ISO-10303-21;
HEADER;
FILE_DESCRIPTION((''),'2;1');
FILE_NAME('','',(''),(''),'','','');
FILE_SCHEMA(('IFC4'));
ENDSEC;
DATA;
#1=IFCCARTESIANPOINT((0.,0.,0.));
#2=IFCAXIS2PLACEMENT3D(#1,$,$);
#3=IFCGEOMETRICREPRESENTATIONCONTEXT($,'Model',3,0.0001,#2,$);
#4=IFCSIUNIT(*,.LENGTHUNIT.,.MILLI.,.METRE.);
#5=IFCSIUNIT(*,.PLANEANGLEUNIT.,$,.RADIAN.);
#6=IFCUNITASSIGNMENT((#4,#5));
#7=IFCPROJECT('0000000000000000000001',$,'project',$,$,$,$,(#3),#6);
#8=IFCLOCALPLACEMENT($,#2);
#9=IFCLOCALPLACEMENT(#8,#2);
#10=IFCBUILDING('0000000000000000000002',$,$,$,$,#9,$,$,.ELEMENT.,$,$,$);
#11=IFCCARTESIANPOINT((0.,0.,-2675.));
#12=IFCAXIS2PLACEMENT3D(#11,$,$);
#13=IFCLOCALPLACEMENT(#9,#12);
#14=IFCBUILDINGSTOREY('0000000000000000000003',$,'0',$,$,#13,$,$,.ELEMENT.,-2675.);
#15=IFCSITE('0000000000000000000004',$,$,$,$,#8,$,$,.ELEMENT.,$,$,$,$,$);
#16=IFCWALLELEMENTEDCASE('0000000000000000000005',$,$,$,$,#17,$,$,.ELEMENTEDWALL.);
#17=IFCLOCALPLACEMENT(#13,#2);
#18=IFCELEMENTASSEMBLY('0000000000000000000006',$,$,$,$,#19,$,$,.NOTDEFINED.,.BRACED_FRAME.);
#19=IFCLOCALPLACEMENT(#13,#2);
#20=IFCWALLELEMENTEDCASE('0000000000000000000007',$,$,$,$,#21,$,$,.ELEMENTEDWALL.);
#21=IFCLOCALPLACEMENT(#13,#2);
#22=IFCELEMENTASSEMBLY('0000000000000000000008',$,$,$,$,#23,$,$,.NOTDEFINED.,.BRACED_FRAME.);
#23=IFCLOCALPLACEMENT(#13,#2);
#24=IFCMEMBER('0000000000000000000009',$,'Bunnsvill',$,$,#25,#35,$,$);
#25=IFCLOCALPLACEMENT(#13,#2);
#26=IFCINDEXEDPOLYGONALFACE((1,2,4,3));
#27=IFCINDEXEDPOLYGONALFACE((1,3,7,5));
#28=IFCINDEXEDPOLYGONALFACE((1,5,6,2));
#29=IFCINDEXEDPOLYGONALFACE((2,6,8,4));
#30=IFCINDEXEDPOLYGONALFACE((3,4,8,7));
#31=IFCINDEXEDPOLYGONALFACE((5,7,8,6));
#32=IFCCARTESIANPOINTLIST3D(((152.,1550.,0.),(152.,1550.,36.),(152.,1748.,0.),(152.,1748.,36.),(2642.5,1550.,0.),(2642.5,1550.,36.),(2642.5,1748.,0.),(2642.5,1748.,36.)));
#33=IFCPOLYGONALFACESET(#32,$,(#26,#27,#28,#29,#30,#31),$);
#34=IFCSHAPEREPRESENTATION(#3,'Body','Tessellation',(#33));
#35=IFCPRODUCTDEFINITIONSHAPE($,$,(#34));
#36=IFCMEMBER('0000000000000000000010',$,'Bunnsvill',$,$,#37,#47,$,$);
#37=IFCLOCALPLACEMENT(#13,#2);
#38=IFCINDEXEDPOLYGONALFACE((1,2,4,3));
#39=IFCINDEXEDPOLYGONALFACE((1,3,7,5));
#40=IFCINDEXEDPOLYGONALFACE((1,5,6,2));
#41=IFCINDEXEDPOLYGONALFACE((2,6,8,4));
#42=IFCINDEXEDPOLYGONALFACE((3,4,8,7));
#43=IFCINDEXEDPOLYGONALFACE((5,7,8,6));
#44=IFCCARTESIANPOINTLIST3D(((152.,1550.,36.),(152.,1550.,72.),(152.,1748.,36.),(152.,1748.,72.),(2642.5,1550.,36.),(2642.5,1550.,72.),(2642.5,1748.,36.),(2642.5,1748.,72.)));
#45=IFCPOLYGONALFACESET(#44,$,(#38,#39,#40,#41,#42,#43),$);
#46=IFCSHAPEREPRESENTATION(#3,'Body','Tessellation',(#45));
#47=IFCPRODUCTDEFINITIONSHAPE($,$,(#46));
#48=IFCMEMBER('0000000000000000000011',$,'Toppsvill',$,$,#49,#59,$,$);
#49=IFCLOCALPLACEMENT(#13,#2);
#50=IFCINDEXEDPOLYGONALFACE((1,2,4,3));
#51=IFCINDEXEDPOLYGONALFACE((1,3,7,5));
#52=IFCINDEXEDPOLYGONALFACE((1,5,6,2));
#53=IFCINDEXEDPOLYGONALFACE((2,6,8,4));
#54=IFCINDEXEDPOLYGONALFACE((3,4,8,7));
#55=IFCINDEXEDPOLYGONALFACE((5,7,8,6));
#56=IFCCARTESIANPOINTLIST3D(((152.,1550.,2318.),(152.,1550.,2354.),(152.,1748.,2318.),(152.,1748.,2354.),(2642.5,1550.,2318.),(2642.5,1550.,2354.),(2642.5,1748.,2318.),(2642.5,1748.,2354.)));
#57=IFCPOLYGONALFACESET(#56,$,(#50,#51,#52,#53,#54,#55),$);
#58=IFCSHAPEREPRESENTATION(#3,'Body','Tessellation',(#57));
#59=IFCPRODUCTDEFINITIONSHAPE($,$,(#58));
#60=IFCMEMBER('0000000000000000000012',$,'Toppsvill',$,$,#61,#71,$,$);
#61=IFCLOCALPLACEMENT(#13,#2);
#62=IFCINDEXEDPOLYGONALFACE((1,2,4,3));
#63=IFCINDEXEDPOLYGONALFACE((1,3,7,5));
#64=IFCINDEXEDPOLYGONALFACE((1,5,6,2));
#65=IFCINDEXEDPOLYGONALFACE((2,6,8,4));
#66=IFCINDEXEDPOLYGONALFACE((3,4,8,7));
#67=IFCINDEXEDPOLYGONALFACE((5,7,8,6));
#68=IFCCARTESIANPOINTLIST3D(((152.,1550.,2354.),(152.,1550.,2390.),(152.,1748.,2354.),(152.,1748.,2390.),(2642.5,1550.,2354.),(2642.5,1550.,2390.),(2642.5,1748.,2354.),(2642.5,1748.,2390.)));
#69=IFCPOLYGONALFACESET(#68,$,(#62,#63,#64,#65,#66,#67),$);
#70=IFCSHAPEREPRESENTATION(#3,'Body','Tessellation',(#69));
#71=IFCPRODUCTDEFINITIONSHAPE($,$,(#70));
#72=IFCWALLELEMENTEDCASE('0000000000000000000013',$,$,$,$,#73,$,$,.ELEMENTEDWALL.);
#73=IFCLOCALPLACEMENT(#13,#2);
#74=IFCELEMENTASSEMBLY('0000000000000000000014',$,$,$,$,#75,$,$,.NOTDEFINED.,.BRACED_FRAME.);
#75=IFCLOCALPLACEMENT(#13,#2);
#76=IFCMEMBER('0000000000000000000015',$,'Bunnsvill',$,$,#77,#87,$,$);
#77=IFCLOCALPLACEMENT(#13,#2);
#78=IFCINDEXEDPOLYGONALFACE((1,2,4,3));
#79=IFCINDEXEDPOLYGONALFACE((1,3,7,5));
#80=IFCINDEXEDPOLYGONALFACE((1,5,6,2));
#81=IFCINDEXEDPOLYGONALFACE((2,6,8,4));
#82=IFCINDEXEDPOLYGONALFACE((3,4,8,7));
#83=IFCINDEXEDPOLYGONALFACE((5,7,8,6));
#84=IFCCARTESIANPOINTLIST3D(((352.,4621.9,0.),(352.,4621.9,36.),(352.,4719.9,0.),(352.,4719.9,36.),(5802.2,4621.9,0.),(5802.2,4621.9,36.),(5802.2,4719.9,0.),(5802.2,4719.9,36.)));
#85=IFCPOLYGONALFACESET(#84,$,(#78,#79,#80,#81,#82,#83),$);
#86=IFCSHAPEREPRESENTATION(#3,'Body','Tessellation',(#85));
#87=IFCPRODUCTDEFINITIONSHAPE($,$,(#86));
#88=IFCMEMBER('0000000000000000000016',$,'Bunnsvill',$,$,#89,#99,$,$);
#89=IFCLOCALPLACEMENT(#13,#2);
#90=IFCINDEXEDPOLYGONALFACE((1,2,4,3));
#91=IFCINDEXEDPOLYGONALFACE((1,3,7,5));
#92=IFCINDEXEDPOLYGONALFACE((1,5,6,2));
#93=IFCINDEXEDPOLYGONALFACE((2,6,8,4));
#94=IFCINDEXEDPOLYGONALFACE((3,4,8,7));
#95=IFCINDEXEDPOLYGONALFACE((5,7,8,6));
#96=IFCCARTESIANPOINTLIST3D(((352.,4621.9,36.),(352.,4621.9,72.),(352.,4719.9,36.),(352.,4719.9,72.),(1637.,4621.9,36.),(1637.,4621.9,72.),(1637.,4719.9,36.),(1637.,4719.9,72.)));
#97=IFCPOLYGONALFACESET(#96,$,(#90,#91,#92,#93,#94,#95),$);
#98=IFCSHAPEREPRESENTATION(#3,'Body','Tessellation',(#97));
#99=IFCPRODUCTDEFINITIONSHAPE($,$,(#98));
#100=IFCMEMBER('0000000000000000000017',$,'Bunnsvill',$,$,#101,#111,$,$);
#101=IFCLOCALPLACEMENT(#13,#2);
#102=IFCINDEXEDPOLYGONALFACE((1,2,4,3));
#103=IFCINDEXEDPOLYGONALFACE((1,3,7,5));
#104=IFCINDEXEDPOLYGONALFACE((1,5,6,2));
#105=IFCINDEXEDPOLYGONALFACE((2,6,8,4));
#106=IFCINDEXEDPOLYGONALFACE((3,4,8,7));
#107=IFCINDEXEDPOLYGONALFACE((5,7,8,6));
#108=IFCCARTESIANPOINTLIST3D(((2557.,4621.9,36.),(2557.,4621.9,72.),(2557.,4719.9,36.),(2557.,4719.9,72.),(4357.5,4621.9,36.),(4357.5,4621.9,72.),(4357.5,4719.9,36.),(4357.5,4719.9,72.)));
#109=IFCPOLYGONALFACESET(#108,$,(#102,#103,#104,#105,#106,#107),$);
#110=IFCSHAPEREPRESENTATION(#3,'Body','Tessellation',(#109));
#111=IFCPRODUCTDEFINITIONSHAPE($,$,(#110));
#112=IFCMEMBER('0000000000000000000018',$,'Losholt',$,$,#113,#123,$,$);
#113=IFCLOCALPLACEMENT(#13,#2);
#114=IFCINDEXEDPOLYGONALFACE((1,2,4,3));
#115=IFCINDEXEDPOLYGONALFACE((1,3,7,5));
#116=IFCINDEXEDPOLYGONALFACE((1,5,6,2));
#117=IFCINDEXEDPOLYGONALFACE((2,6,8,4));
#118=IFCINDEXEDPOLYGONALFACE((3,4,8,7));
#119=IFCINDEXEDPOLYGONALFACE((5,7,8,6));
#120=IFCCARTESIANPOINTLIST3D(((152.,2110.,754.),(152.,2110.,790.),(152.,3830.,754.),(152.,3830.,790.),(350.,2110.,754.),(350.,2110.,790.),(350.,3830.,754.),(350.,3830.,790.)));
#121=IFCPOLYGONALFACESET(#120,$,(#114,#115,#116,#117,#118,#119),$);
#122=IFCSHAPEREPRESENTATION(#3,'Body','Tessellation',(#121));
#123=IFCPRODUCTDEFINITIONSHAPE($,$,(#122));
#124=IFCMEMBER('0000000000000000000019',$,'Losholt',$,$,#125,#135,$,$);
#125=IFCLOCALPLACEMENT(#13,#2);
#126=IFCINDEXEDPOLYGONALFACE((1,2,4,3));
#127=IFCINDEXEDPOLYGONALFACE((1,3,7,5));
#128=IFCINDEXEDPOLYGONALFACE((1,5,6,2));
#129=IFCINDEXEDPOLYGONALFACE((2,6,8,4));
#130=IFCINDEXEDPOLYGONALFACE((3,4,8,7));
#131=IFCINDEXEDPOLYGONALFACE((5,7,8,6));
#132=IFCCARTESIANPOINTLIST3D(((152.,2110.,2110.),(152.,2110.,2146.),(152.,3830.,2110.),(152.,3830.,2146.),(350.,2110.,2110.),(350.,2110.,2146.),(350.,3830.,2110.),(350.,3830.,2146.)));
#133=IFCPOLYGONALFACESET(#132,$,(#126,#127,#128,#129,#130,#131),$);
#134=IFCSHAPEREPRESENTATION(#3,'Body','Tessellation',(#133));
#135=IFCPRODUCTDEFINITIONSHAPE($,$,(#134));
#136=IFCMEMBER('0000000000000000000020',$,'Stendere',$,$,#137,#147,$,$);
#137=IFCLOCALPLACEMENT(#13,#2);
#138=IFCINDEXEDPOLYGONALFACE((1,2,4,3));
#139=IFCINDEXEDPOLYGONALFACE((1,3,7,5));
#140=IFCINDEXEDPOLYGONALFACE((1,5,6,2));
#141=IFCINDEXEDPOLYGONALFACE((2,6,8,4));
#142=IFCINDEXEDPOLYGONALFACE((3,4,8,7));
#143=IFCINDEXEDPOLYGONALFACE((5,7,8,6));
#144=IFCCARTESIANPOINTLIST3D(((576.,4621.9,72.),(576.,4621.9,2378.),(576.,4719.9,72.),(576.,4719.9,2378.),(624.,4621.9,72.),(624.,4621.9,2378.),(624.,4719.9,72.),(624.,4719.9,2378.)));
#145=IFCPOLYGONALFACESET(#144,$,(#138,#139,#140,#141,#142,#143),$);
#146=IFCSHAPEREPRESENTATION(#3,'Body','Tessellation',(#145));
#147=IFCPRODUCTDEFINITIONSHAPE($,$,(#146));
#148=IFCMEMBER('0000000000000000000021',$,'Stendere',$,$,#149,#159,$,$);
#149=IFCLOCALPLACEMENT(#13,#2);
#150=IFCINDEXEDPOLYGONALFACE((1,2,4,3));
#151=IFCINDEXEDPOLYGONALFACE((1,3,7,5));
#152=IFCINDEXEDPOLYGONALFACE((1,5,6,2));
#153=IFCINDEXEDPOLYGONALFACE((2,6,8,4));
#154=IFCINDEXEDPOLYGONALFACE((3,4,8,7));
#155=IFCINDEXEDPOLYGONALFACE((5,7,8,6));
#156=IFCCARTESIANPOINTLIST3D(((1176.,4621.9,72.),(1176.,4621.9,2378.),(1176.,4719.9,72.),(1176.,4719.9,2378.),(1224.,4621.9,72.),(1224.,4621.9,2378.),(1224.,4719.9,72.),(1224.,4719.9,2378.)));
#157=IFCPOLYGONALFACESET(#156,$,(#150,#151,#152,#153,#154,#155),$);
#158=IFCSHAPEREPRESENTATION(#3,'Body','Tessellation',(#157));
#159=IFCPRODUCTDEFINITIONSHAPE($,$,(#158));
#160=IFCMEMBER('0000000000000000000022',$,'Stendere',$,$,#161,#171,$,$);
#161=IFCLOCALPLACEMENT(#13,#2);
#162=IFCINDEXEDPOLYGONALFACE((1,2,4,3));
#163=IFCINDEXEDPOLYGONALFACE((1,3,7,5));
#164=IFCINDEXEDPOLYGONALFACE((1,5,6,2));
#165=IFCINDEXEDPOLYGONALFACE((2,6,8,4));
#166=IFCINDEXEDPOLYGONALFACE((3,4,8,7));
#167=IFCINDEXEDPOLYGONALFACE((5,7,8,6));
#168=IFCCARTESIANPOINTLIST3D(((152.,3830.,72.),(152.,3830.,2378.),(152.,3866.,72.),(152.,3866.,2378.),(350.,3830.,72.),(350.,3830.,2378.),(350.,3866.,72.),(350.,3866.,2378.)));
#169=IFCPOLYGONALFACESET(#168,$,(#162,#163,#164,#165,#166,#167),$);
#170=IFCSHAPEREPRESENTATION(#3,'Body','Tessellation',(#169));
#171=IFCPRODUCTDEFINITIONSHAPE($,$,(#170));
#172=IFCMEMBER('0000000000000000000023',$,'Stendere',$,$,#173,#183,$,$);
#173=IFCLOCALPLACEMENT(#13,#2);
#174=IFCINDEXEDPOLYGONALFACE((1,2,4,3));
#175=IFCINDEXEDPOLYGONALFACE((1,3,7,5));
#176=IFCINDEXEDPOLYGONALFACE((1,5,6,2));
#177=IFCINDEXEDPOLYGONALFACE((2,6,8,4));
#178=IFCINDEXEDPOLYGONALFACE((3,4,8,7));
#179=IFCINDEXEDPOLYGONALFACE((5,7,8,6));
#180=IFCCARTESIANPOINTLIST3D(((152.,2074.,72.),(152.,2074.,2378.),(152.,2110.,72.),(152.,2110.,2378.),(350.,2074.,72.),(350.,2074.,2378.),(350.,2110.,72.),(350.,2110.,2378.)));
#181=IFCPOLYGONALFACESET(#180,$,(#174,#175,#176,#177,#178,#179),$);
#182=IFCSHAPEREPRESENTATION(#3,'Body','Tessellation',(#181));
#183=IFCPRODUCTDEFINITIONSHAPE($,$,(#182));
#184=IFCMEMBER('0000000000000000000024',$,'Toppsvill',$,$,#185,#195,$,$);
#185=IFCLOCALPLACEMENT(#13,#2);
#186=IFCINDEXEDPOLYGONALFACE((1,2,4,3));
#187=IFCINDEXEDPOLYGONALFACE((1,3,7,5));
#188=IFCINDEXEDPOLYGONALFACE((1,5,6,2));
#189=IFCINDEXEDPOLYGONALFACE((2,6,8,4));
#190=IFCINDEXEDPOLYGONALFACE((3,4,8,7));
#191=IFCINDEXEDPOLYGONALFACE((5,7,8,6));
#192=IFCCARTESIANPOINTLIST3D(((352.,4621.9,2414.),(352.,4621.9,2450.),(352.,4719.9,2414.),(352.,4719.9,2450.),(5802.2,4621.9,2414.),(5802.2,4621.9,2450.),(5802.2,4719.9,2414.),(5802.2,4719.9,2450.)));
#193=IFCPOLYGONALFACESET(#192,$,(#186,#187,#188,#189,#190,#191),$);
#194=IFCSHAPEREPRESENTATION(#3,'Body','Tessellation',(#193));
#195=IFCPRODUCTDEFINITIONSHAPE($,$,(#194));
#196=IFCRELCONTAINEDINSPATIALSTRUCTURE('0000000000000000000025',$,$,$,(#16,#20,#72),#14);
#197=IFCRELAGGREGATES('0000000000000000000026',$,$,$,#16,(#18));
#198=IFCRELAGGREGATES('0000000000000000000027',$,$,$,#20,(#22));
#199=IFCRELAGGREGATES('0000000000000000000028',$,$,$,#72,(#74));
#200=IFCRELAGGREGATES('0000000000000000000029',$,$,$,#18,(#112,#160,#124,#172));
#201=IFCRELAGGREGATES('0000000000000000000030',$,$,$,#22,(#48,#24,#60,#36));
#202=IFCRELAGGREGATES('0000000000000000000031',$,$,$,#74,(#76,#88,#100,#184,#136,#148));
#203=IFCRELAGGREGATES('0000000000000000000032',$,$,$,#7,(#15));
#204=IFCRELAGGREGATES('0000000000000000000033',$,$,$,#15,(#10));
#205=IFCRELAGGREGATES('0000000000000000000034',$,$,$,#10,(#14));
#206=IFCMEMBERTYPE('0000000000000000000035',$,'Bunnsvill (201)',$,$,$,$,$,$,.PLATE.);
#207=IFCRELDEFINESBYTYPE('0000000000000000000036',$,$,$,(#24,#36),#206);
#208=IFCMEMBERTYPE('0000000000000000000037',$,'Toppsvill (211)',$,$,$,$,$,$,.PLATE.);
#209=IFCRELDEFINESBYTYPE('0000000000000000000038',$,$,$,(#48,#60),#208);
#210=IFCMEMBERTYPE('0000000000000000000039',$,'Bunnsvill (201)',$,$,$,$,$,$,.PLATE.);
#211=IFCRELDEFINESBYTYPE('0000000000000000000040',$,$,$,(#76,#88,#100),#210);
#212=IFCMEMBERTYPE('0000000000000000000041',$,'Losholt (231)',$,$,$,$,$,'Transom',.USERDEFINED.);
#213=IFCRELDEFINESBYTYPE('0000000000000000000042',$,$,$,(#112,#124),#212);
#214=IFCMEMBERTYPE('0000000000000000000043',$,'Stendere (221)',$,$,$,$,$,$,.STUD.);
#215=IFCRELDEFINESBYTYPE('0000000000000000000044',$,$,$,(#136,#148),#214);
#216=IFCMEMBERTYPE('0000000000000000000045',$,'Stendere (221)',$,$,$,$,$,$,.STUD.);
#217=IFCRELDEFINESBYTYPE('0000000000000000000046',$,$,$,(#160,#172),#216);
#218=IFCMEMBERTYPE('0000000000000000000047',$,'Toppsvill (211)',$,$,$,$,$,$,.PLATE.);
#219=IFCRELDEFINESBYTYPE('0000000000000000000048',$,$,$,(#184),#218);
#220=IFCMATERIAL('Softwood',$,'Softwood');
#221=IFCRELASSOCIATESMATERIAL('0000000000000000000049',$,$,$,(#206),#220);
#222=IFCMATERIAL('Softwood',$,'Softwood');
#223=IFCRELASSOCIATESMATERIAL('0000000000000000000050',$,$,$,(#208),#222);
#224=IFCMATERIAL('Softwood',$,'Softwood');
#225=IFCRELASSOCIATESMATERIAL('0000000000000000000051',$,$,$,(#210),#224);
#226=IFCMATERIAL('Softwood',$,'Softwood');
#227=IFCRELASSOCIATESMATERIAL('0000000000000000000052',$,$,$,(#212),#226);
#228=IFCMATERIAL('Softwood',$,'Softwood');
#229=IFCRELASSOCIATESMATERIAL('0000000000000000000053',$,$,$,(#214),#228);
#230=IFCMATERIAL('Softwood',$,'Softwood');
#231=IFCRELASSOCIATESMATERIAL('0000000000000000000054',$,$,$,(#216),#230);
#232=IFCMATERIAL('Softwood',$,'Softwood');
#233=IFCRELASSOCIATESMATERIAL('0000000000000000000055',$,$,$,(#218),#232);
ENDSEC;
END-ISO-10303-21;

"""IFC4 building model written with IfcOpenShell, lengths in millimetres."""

from ifc_helpers import new_model, si_unit, frame, origin, place, context, project, spatial, rectangle, extrude, material, material_profile, profile_set, type_object, element, aggregate, save


model = new_model("IFC4")

# Units and contexts
model_context = context("Model", 3, precision=0.0001, world=origin())
ifc_project = project(units=[si_unit("LENGTHUNIT", "METRE", prefix="MILLI"), si_unit("PLANEANGLEUNIT", "RADIAN")], contexts=[model_context])

# Site, building, storey
site_placement = place(None, origin())
site = spatial("IfcSite", under=ifc_project, at=site_placement, CompositionType="ELEMENT")
building_placement = place(site_placement, origin())
building = spatial("IfcBuilding", under=site, at=building_placement, CompositionType="ELEMENT")
storey_placement = place(building_placement, frame((0.0, 0.0, -2675.0)))
storey = spatial("IfcBuildingStorey", under=building, at=storey_placement, Name="0", CompositionType="ELEMENT", Elevation=-2675.0)

# Walls, element assemblies
wall_1_placement = place(storey_placement, frame((350.0, 6150.0, 0.0), z_axis=(-1.0, 0.0, 0.0), x_axis=(0.0, -1.0, 0.0)))
wall_1 = element("IfcWallElementedCase", 1, at=wall_1_placement, inside=storey, PredefinedType="ELEMENTEDWALL")
assembly_1_placement = place(wall_1_placement, origin())
assembly_1 = element("IfcElementAssembly", 2, at=assembly_1_placement, AssemblyPlace="NOTDEFINED", PredefinedType="BRACED_FRAME")
aggregate(wall_1, [assembly_1])
wall_2_placement = place(storey_placement, frame((350.0, 1748.0, 0.0), z_axis=(0.0, -1.0, 0.0)))
wall_2 = element("IfcWallElementedCase", 3, at=wall_2_placement, inside=storey, PredefinedType="ELEMENTEDWALL")
assembly_2_placement = place(wall_2_placement, origin())
assembly_2 = element("IfcElementAssembly", 4, at=assembly_2_placement, AssemblyPlace="NOTDEFINED", PredefinedType="BRACED_FRAME")
aggregate(wall_2, [assembly_2])

# Members
ifc_material_1 = material(Name="Softwood", Category="Softwood")
ifc_material_profile_1 = material_profile(ifc_material_1, rectangle(XDim=36.0, YDim=198.0), Name="Bunnsvill (201)")
ifc_profile_set_1 = profile_set([ifc_material_profile_1])
member_type_1 = type_object("IfcMemberType", Name="Bunnsvill (201)", PredefinedType="PLATE", material=ifc_profile_set_1)
member_1_placement = place(assembly_2_placement, frame((-198.0, 18.0, 0.0), z_axis=(1.0, 0.0, 0.0), x_axis=(0.0, 1.0, 0.0)))
member_1 = element("IfcMember", 5, at=member_1_placement, type_object=member_type_1, Name="Bunnsvill", context=model_context, shape_type="SweptSolid", body=[
    extrude(rectangle(XDim=36.0, YDim=198.0), frame((0.0, 99.0, 0.0)), (0.0, 0.0, 1.0), 2490.5),
])
member_2_placement = place(assembly_2_placement, frame((-198.0, 54.0, 0.0), z_axis=(1.0, 0.0, 0.0), x_axis=(0.0, 1.0, 0.0)))
member_2 = element("IfcMember", 6, at=member_2_placement, type_object=member_type_1, Name="Bunnsvill", context=model_context, shape_type="SweptSolid", body=[
    extrude(rectangle(XDim=36.0, YDim=198.0), frame((0.0, 99.0, 0.0)), (0.0, 0.0, 1.0), 2490.5),
])
ifc_material_2 = material(Name="Softwood", Category="Softwood")
ifc_material_profile_2 = material_profile(ifc_material_2, rectangle(XDim=36.0, YDim=198.0), Name="Toppsvill (211)")
ifc_profile_set_2 = profile_set([ifc_material_profile_2])
member_type_2 = type_object("IfcMemberType", Name="Toppsvill (211)", PredefinedType="PLATE", material=ifc_profile_set_2)
member_3_placement = place(assembly_2_placement, frame((-198.0, 2336.0, 0.0), z_axis=(1.0, 0.0, 0.0), x_axis=(0.0, 1.0, 0.0)))
member_3 = element("IfcMember", 7, at=member_3_placement, type_object=member_type_2, Name="Toppsvill", context=model_context, shape_type="SweptSolid", body=[
    extrude(rectangle(XDim=36.0, YDim=198.0), frame((0.0, 99.0, 0.0)), (0.0, 0.0, 1.0), 2490.5),
])
member_4_placement = place(assembly_2_placement, frame((-198.0, 2372.0, 0.0), z_axis=(1.0, 0.0, 0.0), x_axis=(0.0, 1.0, 0.0)))
member_4 = element("IfcMember", 8, at=member_4_placement, type_object=member_type_2, Name="Toppsvill", context=model_context, shape_type="SweptSolid", body=[
    extrude(rectangle(XDim=36.0, YDim=198.0), frame((0.0, 99.0, 0.0)), (0.0, 0.0, 1.0), 2490.5),
])

# Wall, element assembly, members
wall_3_placement = place(storey_placement, frame((352.0, 4719.9, 0.0), z_axis=(0.0, -1.0, 0.0)))
wall_3 = element("IfcWallElementedCase", 9, at=wall_3_placement, inside=storey, PredefinedType="ELEMENTEDWALL")
assembly_3_placement = place(wall_3_placement, origin())
assembly_3 = element("IfcElementAssembly", 10, at=assembly_3_placement, AssemblyPlace="NOTDEFINED", PredefinedType="BRACED_FRAME")
aggregate(wall_3, [assembly_3])
ifc_material_3 = material(Name="Softwood", Category="Softwood")
ifc_material_profile_3 = material_profile(ifc_material_3, rectangle(XDim=36.0, YDim=98.0), Name="Bunnsvill (201)")
ifc_profile_set_3 = profile_set([ifc_material_profile_3])
member_type_3 = type_object("IfcMemberType", Name="Bunnsvill (201)", PredefinedType="PLATE", material=ifc_profile_set_3)
member_5_placement = place(assembly_3_placement, frame((0.0, 18.0, 0.0), z_axis=(1.0, 0.0, 0.0), x_axis=(0.0, 1.0, 0.0)))
member_5 = element("IfcMember", 11, at=member_5_placement, type_object=member_type_3, Name="Bunnsvill", context=model_context, shape_type="SweptSolid", body=[
    extrude(rectangle(XDim=36.0, YDim=98.0), frame((0.0, 49.0, 0.0)), (0.0, 0.0, 1.0), 5450.2),
])
member_6_placement = place(assembly_3_placement, frame((0.0, 54.0, 0.0), z_axis=(1.0, 0.0, 0.0), x_axis=(0.0, 1.0, 0.0)))
member_6 = element("IfcMember", 12, at=member_6_placement, type_object=member_type_3, Name="Bunnsvill", context=model_context, shape_type="SweptSolid", body=[
    extrude(rectangle(XDim=36.0, YDim=98.0), frame((0.0, 49.0, 0.0)), (0.0, 0.0, 1.0), 1285.0),
])
member_7_placement = place(assembly_3_placement, frame((2205.0, 54.0, 0.0), z_axis=(1.0, 0.0, 0.0), x_axis=(0.0, 1.0, 0.0)))
member_7 = element("IfcMember", 13, at=member_7_placement, type_object=member_type_3, Name="Bunnsvill", context=model_context, shape_type="SweptSolid", body=[
    extrude(rectangle(XDim=36.0, YDim=98.0), frame((0.0, 49.0, 0.0)), (0.0, 0.0, 1.0), 1800.5),
])

# Members
ifc_material_4 = material(Name="Softwood", Category="Softwood")
ifc_material_profile_4 = material_profile(ifc_material_4, rectangle(XDim=36.0, YDim=198.0), Name="Losholt (231)")
ifc_profile_set_4 = profile_set([ifc_material_profile_4])
member_type_4 = type_object("IfcMemberType", Name="Losholt (231)", ElementType="Transom", PredefinedType="USERDEFINED", material=ifc_profile_set_4)
member_8_placement = place(assembly_1_placement, frame((2320.0, 772.0, 0.0), z_axis=(1.0, 0.0, 0.0), x_axis=(0.0, 1.0, 0.0)))
member_8 = element("IfcMember", 14, at=member_8_placement, type_object=member_type_4, Name="Losholt", context=model_context, shape_type="SweptSolid", body=[
    extrude(rectangle(XDim=36.0, YDim=198.0), frame((0.0, 99.0, 0.0)), (0.0, 0.0, 1.0), 1720.0),
])
member_9_placement = place(assembly_1_placement, frame((2320.0, 2128.0, 0.0), z_axis=(1.0, 0.0, 0.0), x_axis=(0.0, 1.0, 0.0)))
member_9 = element("IfcMember", 15, at=member_9_placement, type_object=member_type_4, Name="Losholt", context=model_context, shape_type="SweptSolid", body=[
    extrude(rectangle(XDim=36.0, YDim=198.0), frame((0.0, 99.0, 0.0)), (0.0, 0.0, 1.0), 1720.0),
])
ifc_material_5 = material(Name="Softwood", Category="Softwood")
ifc_material_profile_5 = material_profile(ifc_material_5, rectangle(XDim=48.0, YDim=98.0), Name="Stendere (221)")
ifc_profile_set_5 = profile_set([ifc_material_profile_5])
member_type_5 = type_object("IfcMemberType", Name="Stendere (221)", PredefinedType="STUD", material=ifc_profile_set_5)
member_10_placement = place(assembly_3_placement, frame((248.0, 72.0, 0.0), z_axis=(0.0, 1.0, 0.0), x_axis=(-1.0, 0.0, 0.0)))
member_10 = element("IfcMember", 16, at=member_10_placement, type_object=member_type_5, Name="Stendere", context=model_context, shape_type="SweptSolid", body=[
    extrude(rectangle(XDim=48.0, YDim=98.0), frame((0.0, 49.0, 0.0)), (0.0, 0.0, 1.0), 2306.0),
])
member_11_placement = place(assembly_3_placement, frame((848.0, 72.0, 0.0), z_axis=(0.0, 1.0, 0.0), x_axis=(-1.0, 0.0, 0.0)))
member_11 = element("IfcMember", 17, at=member_11_placement, type_object=member_type_5, Name="Stendere", context=model_context, shape_type="SweptSolid", body=[
    extrude(rectangle(XDim=48.0, YDim=98.0), frame((0.0, 49.0, 0.0)), (0.0, 0.0, 1.0), 2306.0),
])
ifc_material_6 = material(Name="Softwood", Category="Softwood")
ifc_material_profile_6 = material_profile(ifc_material_6, rectangle(XDim=36.0, YDim=198.0), Name="Stendere (221)")
ifc_profile_set_6 = profile_set([ifc_material_profile_6])
member_type_6 = type_object("IfcMemberType", Name="Stendere (221)", PredefinedType="STUD", material=ifc_profile_set_6)
member_12_placement = place(assembly_1_placement, frame((2302.0, 72.0, 0.0), z_axis=(0.0, 1.0, 0.0), x_axis=(-1.0, 0.0, 0.0)))
member_12 = element("IfcMember", 18, at=member_12_placement, type_object=member_type_6, Name="Stendere", context=model_context, shape_type="SweptSolid", body=[
    extrude(rectangle(XDim=36.0, YDim=198.0), frame((0.0, 99.0, 0.0)), (0.0, 0.0, 1.0), 2306.0),
])
member_13_placement = place(assembly_1_placement, frame((4058.0, 72.0, 0.0), z_axis=(0.0, 1.0, 0.0), x_axis=(-1.0, 0.0, 0.0)))
member_13 = element("IfcMember", 19, at=member_13_placement, type_object=member_type_6, Name="Stendere", context=model_context, shape_type="SweptSolid", body=[
    extrude(rectangle(XDim=36.0, YDim=198.0), frame((0.0, 99.0, 0.0)), (0.0, 0.0, 1.0), 2306.0),
])
aggregate(assembly_1, [member_8, member_12, member_9, member_13])
ifc_material_7 = material(Name="Softwood", Category="Softwood")
ifc_material_profile_7 = material_profile(ifc_material_7, rectangle(XDim=36.0, YDim=98.0), Name="Toppsvill (211)")
ifc_profile_set_7 = profile_set([ifc_material_profile_7])
member_type_7 = type_object("IfcMemberType", Name="Toppsvill (211)", PredefinedType="PLATE", material=ifc_profile_set_7)
member_14_placement = place(assembly_3_placement, frame((0.0, 2432.0, 0.0), z_axis=(1.0, 0.0, 0.0), x_axis=(0.0, 1.0, 0.0)))
member_14 = element("IfcMember", 20, at=member_14_placement, type_object=member_type_7, Name="Toppsvill", context=model_context, shape_type="SweptSolid", body=[
    extrude(rectangle(XDim=36.0, YDim=98.0), frame((0.0, 49.0, 0.0)), (0.0, 0.0, 1.0), 5450.2),
])

aggregate(assembly_2, [member_3, member_1, member_4, member_2])
aggregate(assembly_3, [member_5, member_6, member_7, member_14, member_10, member_11])

save(model, "model.ifc")
